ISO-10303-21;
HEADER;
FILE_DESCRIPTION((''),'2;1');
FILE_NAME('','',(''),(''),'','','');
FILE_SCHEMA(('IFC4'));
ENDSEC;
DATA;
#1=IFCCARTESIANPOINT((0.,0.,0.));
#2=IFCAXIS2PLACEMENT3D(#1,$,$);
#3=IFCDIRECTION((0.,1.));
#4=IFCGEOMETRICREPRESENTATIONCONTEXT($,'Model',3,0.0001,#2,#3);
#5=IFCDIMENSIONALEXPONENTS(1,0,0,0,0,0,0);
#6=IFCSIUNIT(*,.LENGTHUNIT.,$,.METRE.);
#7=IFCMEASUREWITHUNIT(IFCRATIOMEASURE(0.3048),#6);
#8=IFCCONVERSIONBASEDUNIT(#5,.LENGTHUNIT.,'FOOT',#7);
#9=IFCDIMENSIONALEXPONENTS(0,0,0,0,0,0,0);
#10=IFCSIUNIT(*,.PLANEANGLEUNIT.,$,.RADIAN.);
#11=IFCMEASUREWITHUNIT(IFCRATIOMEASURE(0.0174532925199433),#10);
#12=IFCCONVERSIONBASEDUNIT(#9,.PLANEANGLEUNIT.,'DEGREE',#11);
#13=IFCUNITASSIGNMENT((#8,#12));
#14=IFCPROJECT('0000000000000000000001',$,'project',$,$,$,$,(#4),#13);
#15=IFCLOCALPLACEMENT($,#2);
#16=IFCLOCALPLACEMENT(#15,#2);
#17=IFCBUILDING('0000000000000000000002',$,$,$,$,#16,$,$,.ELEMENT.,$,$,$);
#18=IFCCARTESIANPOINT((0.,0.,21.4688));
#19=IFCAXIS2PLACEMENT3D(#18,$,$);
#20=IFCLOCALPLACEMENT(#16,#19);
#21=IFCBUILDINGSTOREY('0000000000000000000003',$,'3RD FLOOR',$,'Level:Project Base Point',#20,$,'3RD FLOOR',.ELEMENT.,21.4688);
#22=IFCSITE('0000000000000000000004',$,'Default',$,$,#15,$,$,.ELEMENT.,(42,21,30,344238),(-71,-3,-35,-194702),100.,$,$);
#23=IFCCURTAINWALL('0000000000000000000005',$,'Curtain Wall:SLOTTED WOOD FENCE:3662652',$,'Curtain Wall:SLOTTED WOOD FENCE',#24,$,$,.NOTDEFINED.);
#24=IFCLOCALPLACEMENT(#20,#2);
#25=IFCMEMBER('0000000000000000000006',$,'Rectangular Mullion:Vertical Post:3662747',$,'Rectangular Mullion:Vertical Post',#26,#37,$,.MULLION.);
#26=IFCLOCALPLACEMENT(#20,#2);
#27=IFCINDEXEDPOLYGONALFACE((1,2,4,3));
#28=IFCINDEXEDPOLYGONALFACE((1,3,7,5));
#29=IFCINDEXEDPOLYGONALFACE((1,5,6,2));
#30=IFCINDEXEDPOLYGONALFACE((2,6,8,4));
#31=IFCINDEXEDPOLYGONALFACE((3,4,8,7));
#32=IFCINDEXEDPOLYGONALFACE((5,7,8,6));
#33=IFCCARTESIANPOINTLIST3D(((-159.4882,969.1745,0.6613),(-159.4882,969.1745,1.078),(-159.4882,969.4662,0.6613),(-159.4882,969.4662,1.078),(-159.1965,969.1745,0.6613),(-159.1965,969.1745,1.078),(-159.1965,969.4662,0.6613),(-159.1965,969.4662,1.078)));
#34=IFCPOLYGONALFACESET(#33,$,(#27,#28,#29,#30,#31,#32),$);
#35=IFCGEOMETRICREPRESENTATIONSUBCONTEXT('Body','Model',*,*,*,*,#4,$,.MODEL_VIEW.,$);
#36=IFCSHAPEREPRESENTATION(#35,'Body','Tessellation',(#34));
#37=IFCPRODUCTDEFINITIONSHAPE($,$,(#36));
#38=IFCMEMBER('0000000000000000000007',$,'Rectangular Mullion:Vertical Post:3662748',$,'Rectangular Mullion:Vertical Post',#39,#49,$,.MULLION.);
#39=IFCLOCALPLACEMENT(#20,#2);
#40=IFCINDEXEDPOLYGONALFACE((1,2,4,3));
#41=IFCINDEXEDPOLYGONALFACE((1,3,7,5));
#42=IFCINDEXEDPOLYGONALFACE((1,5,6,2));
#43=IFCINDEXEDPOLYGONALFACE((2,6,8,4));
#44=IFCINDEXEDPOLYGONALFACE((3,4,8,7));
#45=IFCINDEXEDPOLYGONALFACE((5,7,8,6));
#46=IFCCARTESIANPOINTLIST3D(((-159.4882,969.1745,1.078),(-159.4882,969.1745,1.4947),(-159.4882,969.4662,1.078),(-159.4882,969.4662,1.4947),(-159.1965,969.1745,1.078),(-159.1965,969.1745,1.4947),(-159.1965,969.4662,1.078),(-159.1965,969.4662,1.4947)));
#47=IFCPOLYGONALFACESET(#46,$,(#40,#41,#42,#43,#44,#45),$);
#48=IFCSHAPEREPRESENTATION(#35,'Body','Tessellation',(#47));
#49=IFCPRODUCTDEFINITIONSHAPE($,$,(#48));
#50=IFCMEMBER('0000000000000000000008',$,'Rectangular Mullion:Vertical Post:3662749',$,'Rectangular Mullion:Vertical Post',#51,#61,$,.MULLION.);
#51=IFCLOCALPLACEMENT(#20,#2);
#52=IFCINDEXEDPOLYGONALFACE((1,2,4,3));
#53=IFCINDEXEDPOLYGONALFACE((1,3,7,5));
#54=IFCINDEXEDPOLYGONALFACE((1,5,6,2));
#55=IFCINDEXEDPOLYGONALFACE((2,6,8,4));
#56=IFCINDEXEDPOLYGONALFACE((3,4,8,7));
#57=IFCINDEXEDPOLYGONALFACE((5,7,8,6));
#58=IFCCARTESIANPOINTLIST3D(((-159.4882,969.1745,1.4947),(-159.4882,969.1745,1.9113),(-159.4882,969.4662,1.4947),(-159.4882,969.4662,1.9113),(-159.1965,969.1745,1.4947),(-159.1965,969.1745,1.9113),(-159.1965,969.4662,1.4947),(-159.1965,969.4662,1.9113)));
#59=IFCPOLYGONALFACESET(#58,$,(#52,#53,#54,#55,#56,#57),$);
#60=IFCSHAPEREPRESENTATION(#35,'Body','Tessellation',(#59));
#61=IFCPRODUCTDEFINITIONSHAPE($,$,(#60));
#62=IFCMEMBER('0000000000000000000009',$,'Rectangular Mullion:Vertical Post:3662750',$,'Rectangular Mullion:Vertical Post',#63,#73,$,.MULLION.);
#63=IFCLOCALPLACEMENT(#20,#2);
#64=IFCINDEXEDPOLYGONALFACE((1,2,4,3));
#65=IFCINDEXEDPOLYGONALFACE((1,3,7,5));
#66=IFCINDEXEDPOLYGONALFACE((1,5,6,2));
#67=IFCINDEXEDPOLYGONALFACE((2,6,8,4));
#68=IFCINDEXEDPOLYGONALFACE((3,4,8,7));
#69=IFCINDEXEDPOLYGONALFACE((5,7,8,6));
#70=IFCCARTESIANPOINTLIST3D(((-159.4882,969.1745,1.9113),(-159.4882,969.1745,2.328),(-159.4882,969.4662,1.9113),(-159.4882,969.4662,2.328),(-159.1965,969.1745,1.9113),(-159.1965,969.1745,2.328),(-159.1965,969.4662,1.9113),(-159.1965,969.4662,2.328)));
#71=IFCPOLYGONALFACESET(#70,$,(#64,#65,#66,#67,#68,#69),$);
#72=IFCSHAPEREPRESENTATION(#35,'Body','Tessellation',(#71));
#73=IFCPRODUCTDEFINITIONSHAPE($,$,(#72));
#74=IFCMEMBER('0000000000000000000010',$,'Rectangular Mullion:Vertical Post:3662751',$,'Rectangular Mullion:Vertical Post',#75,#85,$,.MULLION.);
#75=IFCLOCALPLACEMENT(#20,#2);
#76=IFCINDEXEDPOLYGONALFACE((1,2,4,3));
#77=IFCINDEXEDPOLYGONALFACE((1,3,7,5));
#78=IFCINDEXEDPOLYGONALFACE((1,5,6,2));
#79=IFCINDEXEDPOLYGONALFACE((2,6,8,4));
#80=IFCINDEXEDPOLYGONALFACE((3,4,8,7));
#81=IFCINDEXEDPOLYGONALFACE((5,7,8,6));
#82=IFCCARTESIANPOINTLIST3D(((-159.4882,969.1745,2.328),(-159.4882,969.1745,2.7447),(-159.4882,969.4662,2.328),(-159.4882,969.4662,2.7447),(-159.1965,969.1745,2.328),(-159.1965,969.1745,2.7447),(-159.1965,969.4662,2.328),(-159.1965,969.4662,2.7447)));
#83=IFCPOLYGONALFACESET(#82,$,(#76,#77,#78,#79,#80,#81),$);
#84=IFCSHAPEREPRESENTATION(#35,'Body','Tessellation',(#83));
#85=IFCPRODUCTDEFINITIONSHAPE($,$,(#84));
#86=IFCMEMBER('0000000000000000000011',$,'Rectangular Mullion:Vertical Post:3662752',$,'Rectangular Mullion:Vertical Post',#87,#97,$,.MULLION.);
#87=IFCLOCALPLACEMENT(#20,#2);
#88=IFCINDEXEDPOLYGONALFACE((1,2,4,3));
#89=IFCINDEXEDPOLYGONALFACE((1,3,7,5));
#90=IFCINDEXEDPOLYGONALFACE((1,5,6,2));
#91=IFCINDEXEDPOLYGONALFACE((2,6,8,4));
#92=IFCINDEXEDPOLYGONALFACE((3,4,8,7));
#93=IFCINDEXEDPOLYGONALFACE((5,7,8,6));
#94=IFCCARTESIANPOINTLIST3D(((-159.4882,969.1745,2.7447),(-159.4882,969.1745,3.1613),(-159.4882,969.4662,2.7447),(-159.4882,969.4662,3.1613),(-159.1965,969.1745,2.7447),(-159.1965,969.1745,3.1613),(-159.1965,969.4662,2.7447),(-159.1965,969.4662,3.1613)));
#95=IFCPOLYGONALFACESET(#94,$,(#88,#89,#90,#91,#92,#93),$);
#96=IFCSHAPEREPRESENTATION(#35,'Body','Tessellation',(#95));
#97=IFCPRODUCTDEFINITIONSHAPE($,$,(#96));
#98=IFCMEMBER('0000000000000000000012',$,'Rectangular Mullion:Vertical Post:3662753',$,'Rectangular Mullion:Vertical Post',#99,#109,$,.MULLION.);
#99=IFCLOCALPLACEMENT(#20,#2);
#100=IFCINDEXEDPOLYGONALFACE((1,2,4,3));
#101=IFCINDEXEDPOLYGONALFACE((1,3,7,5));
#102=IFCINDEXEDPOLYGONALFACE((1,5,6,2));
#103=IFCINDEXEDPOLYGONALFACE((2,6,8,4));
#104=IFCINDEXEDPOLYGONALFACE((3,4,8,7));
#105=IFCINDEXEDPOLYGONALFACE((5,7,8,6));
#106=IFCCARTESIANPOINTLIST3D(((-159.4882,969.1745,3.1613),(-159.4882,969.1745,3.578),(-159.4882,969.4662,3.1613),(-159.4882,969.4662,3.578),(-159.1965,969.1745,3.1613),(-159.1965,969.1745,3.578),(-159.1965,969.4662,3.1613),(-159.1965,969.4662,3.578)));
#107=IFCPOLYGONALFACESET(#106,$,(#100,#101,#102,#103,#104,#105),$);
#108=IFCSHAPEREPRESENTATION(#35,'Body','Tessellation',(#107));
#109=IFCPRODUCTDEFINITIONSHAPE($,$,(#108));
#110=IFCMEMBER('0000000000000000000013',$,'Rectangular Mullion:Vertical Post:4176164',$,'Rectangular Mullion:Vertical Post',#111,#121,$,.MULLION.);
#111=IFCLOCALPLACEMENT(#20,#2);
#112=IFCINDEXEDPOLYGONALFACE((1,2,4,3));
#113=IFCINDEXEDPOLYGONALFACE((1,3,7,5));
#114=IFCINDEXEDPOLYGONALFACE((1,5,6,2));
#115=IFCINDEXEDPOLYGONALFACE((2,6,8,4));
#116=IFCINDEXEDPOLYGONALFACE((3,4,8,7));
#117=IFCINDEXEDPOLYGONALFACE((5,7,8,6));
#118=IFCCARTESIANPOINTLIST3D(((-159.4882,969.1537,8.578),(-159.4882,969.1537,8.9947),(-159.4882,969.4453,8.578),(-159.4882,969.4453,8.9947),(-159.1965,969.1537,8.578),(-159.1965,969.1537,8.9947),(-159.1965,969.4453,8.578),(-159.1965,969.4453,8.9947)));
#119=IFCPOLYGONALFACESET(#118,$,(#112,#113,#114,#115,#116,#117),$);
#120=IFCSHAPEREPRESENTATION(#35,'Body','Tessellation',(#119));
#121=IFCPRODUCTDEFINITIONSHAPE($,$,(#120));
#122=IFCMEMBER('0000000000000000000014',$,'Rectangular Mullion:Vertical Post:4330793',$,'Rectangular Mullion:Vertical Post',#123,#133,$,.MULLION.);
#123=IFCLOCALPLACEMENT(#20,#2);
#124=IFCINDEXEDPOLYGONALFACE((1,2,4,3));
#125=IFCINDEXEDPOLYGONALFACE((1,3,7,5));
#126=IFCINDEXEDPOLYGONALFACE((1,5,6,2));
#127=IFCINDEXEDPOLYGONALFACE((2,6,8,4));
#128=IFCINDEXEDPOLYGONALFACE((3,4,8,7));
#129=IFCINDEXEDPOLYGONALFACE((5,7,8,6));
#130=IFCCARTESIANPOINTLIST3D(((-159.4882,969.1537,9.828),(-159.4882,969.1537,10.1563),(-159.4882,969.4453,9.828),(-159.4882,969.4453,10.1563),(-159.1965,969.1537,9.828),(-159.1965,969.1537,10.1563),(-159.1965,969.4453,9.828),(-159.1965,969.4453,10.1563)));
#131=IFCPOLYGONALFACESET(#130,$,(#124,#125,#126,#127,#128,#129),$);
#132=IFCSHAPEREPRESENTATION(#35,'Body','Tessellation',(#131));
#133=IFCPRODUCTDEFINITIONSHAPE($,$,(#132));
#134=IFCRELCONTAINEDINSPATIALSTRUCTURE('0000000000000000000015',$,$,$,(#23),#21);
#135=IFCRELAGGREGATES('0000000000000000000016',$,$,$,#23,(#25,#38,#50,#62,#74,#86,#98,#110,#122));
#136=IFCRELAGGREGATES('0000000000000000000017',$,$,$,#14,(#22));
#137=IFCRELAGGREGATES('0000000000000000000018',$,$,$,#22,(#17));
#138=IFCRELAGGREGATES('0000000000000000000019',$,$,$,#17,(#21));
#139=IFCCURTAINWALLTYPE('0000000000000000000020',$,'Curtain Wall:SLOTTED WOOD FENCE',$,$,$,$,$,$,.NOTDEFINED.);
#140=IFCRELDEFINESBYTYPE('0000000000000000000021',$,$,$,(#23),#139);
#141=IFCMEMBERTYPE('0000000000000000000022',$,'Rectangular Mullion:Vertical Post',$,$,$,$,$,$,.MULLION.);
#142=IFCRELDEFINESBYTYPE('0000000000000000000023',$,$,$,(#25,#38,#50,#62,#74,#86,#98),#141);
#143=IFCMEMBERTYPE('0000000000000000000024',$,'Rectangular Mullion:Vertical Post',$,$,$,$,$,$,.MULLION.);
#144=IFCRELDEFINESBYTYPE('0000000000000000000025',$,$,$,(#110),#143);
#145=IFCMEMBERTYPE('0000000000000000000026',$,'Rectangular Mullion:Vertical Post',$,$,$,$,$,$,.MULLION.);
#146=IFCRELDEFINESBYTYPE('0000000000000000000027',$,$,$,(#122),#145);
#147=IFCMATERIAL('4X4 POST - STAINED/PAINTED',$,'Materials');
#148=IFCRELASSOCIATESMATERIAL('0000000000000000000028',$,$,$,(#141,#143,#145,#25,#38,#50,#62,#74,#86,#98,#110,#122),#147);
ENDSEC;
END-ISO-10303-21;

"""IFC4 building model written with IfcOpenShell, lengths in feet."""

from ifc_helpers import new_model, entity, si_unit, converted_unit, direction, frame, origin, origin_2d_with_axis, place, context, subcontext, project, spatial, rectangle, extrude, source, transform, mapped, material, material_profile, profile_set, profile_usage, type_object, type_shapes, element, aggregate, save


model = new_model("IFC4")

# Units and contexts
model_context = context("Model", 3, precision=0.0001, world=origin(), true_north=direction((0.0, 1.0)))
body_context = subcontext(model_context, "Body", "Model", "MODEL_VIEW")
ifc_project = project(units=[converted_unit("LENGTHUNIT", "FOOT", entity("IfcRatioMeasure", 0.3048), si_unit("LENGTHUNIT", "METRE"), dimensions=[1, 0, 0, 0, 0, 0, 0]), converted_unit("PLANEANGLEUNIT", "DEGREE", entity("IfcRatioMeasure", 0.0174532925199433), si_unit("PLANEANGLEUNIT", "RADIAN"), dimensions=[0, 0, 0, 0, 0, 0, 0])], contexts=[model_context])

# Site, building, storey
site_placement = place(None, origin())
site = spatial("IfcSite", under=ifc_project, at=site_placement, Name="Default", CompositionType="ELEMENT", RefLatitude=(42, 21, 30, 344238), RefLongitude=(-71, -3, -35, -194702), RefElevation=100.0)
building_placement = place(site_placement, origin())
building = spatial("IfcBuilding", under=site, at=building_placement, CompositionType="ELEMENT")
storey_placement = place(building_placement, frame((0.0, 0.0, 21.4688)))
storey = spatial("IfcBuildingStorey", under=building, at=storey_placement, Name="3RD FLOOR", ObjectType="Level:Project Base Point", LongName="3RD FLOOR", CompositionType="ELEMENT", Elevation=21.4688)

# Curtain wall, members
curtain_wall_type = type_object("IfcCurtainWallType", Name="Curtain Wall:SLOTTED WOOD FENCE", PredefinedType="NOTDEFINED")
curtain_wall_placement = place(storey_placement, frame((0.0, 0.0, -21.4688)))
curtain_wall = element("IfcCurtainWall", 1, at=curtain_wall_placement, inside=storey, type_object=curtain_wall_type, Name="Curtain Wall:SLOTTED WOOD FENCE:3662652", ObjectType="Curtain Wall:SLOTTED WOOD FENCE", PredefinedType="NOTDEFINED")
ifc_material = material(Name="4X4 POST - STAINED/PAINTED", Category="Materials")
ifc_material_profile = material_profile(ifc_material, rectangle(XDim=0.2917, YDim=0.2917, at=origin_2d_with_axis()), Name="Vertical Post")
ifc_profile_set = profile_set([ifc_material_profile], Name="Vertical Post")
member_type_1 = type_object("IfcMemberType", Name="Rectangular Mullion:Vertical Post", PredefinedType="MULLION", material=ifc_profile_set)
shared_shape_1 = source(origin(), body_context, "Body", "SweptSolid", [
    extrude(rectangle(XDim=0.2917, YDim=0.2917, at=origin_2d_with_axis()), frame((-0.1458, -0.2083, -0.4167), z_axis=(0.0, 0.0, 1.0), x_axis=(0.0, -1.0, 0.0)), (0.0, 0.0, 1.0), 0.4167),
])
type_shapes(member_type_1, [shared_shape_1])
ifc_profile_usage_1 = profile_usage(ifc_profile_set)
member_1_placement = place(storey_placement, frame((-159.5507, 969.4662, 1.078), z_axis=(0.0, 0.0, 1.0), x_axis=(0.0, 1.0, 0.0)))
member_1 = element("IfcMember", 2, at=member_1_placement, type_object=member_type_1, material=ifc_profile_usage_1, Name="Rectangular Mullion:Vertical Post:3662747", ObjectType="Rectangular Mullion:Vertical Post", PredefinedType="MULLION", context=body_context, shape_type="MappedRepresentation", body=[
    mapped(shared_shape_1, transform((0.0, 0.0, 0.0), scale=1.0)),
])
ifc_profile_usage_2 = profile_usage(ifc_profile_set)
member_2_placement = place(storey_placement, frame((-159.5507, 969.4662, 1.4947), z_axis=(0.0, 0.0, 1.0), x_axis=(0.0, 1.0, 0.0)))
member_2 = element("IfcMember", 3, at=member_2_placement, type_object=member_type_1, material=ifc_profile_usage_2, Name="Rectangular Mullion:Vertical Post:3662748", ObjectType="Rectangular Mullion:Vertical Post", PredefinedType="MULLION", context=body_context, shape_type="MappedRepresentation", body=[
    mapped(shared_shape_1, transform((0.0, 0.0, 0.0), scale=1.0)),
])
ifc_profile_usage_3 = profile_usage(ifc_profile_set)
member_3_placement = place(storey_placement, frame((-159.5507, 969.4662, 1.9113), z_axis=(0.0, 0.0, 1.0), x_axis=(0.0, 1.0, 0.0)))
member_3 = element("IfcMember", 4, at=member_3_placement, type_object=member_type_1, material=ifc_profile_usage_3, Name="Rectangular Mullion:Vertical Post:3662749", ObjectType="Rectangular Mullion:Vertical Post", PredefinedType="MULLION", context=body_context, shape_type="MappedRepresentation", body=[
    mapped(shared_shape_1, transform((0.0, 0.0, 0.0), scale=1.0)),
])
ifc_profile_usage_4 = profile_usage(ifc_profile_set)
member_4_placement = place(storey_placement, frame((-159.5507, 969.4662, 2.328), z_axis=(0.0, 0.0, 1.0), x_axis=(0.0, 1.0, 0.0)))
member_4 = element("IfcMember", 5, at=member_4_placement, type_object=member_type_1, material=ifc_profile_usage_4, Name="Rectangular Mullion:Vertical Post:3662750", ObjectType="Rectangular Mullion:Vertical Post", PredefinedType="MULLION", context=body_context, shape_type="MappedRepresentation", body=[
    mapped(shared_shape_1, transform((0.0, 0.0, 0.0), scale=1.0)),
])
ifc_profile_usage_5 = profile_usage(ifc_profile_set)
member_5_placement = place(storey_placement, frame((-159.5507, 969.4662, 2.7447), z_axis=(0.0, 0.0, 1.0), x_axis=(0.0, 1.0, 0.0)))
member_5 = element("IfcMember", 6, at=member_5_placement, type_object=member_type_1, material=ifc_profile_usage_5, Name="Rectangular Mullion:Vertical Post:3662751", ObjectType="Rectangular Mullion:Vertical Post", PredefinedType="MULLION", context=body_context, shape_type="MappedRepresentation", body=[
    mapped(shared_shape_1, transform((0.0, 0.0, 0.0), scale=1.0)),
])
ifc_profile_usage_6 = profile_usage(ifc_profile_set)
member_6_placement = place(storey_placement, frame((-159.5507, 969.4662, 3.1613), z_axis=(0.0, 0.0, 1.0), x_axis=(0.0, 1.0, 0.0)))
member_6 = element("IfcMember", 7, at=member_6_placement, type_object=member_type_1, material=ifc_profile_usage_6, Name="Rectangular Mullion:Vertical Post:3662752", ObjectType="Rectangular Mullion:Vertical Post", PredefinedType="MULLION", context=body_context, shape_type="MappedRepresentation", body=[
    mapped(shared_shape_1, transform((0.0, 0.0, 0.0), scale=1.0)),
])
ifc_profile_usage_7 = profile_usage(ifc_profile_set)
member_7_placement = place(storey_placement, frame((-159.5507, 969.4662, 3.578), z_axis=(0.0, 0.0, 1.0), x_axis=(0.0, 1.0, 0.0)))
member_7 = element("IfcMember", 8, at=member_7_placement, type_object=member_type_1, material=ifc_profile_usage_7, Name="Rectangular Mullion:Vertical Post:3662753", ObjectType="Rectangular Mullion:Vertical Post", PredefinedType="MULLION", context=body_context, shape_type="MappedRepresentation", body=[
    mapped(shared_shape_1, transform((0.0, 0.0, 0.0), scale=1.0)),
])
ifc_profile_usage_8 = profile_usage(ifc_profile_set)
member_type_2 = type_object("IfcMemberType", Name="Rectangular Mullion:Vertical Post", PredefinedType="MULLION", material=ifc_profile_set)
shared_shape_2 = source(origin(), body_context, "Body", "SweptSolid", [
    extrude(rectangle(XDim=0.2917, YDim=0.2917, at=origin_2d_with_axis()), frame((0.0, -0.2083, -0.4167), z_axis=(0.0, 0.0, 1.0), x_axis=(0.0, -1.0, 0.0)), (0.0, 0.0, 1.0), 0.4167),
])
type_shapes(member_type_2, [shared_shape_2])
member_8_placement = place(storey_placement, frame((-159.5507, 969.2995, 8.578), z_axis=(0.0, 0.0, -1.0), x_axis=(0.0, -1.0, 0.0)))
member_8 = element("IfcMember", 9, at=member_8_placement, type_object=member_type_2, material=ifc_profile_usage_8, Name="Rectangular Mullion:Vertical Post:4176164", ObjectType="Rectangular Mullion:Vertical Post", PredefinedType="MULLION", context=body_context, shape_type="MappedRepresentation", body=[
    mapped(shared_shape_2, transform((0.0, 0.0, 0.0), scale=1.0)),
])
ifc_profile_usage_9 = profile_usage(ifc_profile_set)
member_type_3 = type_object("IfcMemberType", Name="Rectangular Mullion:Vertical Post", PredefinedType="MULLION", material=ifc_profile_set)
shared_shape_3 = source(origin(), body_context, "Body", "SweptSolid", [
    extrude(rectangle(XDim=0.2917, YDim=0.2917, at=origin_2d_with_axis()), frame((0.0, -0.2083, -0.3282), z_axis=(0.0, 0.0, 1.0), x_axis=(0.0, -1.0, 0.0)), (0.0, 0.0, 1.0), 0.3282),
])
type_shapes(member_type_3, [shared_shape_3])
member_9_placement = place(storey_placement, frame((-159.5507, 969.2995, 9.828), z_axis=(0.0, 0.0, -1.0), x_axis=(0.0, -1.0, 0.0)))
member_9 = element("IfcMember", 10, at=member_9_placement, type_object=member_type_3, material=ifc_profile_usage_9, Name="Rectangular Mullion:Vertical Post:4330793", ObjectType="Rectangular Mullion:Vertical Post", PredefinedType="MULLION", context=body_context, shape_type="MappedRepresentation", body=[
    mapped(shared_shape_3, transform((0.0, 0.0, 0.0), scale=1.0)),
])
aggregate(curtain_wall, [member_1, member_2, member_3, member_4, member_5, member_6, member_7, member_8, member_9])

save(model, "model.ifc")
